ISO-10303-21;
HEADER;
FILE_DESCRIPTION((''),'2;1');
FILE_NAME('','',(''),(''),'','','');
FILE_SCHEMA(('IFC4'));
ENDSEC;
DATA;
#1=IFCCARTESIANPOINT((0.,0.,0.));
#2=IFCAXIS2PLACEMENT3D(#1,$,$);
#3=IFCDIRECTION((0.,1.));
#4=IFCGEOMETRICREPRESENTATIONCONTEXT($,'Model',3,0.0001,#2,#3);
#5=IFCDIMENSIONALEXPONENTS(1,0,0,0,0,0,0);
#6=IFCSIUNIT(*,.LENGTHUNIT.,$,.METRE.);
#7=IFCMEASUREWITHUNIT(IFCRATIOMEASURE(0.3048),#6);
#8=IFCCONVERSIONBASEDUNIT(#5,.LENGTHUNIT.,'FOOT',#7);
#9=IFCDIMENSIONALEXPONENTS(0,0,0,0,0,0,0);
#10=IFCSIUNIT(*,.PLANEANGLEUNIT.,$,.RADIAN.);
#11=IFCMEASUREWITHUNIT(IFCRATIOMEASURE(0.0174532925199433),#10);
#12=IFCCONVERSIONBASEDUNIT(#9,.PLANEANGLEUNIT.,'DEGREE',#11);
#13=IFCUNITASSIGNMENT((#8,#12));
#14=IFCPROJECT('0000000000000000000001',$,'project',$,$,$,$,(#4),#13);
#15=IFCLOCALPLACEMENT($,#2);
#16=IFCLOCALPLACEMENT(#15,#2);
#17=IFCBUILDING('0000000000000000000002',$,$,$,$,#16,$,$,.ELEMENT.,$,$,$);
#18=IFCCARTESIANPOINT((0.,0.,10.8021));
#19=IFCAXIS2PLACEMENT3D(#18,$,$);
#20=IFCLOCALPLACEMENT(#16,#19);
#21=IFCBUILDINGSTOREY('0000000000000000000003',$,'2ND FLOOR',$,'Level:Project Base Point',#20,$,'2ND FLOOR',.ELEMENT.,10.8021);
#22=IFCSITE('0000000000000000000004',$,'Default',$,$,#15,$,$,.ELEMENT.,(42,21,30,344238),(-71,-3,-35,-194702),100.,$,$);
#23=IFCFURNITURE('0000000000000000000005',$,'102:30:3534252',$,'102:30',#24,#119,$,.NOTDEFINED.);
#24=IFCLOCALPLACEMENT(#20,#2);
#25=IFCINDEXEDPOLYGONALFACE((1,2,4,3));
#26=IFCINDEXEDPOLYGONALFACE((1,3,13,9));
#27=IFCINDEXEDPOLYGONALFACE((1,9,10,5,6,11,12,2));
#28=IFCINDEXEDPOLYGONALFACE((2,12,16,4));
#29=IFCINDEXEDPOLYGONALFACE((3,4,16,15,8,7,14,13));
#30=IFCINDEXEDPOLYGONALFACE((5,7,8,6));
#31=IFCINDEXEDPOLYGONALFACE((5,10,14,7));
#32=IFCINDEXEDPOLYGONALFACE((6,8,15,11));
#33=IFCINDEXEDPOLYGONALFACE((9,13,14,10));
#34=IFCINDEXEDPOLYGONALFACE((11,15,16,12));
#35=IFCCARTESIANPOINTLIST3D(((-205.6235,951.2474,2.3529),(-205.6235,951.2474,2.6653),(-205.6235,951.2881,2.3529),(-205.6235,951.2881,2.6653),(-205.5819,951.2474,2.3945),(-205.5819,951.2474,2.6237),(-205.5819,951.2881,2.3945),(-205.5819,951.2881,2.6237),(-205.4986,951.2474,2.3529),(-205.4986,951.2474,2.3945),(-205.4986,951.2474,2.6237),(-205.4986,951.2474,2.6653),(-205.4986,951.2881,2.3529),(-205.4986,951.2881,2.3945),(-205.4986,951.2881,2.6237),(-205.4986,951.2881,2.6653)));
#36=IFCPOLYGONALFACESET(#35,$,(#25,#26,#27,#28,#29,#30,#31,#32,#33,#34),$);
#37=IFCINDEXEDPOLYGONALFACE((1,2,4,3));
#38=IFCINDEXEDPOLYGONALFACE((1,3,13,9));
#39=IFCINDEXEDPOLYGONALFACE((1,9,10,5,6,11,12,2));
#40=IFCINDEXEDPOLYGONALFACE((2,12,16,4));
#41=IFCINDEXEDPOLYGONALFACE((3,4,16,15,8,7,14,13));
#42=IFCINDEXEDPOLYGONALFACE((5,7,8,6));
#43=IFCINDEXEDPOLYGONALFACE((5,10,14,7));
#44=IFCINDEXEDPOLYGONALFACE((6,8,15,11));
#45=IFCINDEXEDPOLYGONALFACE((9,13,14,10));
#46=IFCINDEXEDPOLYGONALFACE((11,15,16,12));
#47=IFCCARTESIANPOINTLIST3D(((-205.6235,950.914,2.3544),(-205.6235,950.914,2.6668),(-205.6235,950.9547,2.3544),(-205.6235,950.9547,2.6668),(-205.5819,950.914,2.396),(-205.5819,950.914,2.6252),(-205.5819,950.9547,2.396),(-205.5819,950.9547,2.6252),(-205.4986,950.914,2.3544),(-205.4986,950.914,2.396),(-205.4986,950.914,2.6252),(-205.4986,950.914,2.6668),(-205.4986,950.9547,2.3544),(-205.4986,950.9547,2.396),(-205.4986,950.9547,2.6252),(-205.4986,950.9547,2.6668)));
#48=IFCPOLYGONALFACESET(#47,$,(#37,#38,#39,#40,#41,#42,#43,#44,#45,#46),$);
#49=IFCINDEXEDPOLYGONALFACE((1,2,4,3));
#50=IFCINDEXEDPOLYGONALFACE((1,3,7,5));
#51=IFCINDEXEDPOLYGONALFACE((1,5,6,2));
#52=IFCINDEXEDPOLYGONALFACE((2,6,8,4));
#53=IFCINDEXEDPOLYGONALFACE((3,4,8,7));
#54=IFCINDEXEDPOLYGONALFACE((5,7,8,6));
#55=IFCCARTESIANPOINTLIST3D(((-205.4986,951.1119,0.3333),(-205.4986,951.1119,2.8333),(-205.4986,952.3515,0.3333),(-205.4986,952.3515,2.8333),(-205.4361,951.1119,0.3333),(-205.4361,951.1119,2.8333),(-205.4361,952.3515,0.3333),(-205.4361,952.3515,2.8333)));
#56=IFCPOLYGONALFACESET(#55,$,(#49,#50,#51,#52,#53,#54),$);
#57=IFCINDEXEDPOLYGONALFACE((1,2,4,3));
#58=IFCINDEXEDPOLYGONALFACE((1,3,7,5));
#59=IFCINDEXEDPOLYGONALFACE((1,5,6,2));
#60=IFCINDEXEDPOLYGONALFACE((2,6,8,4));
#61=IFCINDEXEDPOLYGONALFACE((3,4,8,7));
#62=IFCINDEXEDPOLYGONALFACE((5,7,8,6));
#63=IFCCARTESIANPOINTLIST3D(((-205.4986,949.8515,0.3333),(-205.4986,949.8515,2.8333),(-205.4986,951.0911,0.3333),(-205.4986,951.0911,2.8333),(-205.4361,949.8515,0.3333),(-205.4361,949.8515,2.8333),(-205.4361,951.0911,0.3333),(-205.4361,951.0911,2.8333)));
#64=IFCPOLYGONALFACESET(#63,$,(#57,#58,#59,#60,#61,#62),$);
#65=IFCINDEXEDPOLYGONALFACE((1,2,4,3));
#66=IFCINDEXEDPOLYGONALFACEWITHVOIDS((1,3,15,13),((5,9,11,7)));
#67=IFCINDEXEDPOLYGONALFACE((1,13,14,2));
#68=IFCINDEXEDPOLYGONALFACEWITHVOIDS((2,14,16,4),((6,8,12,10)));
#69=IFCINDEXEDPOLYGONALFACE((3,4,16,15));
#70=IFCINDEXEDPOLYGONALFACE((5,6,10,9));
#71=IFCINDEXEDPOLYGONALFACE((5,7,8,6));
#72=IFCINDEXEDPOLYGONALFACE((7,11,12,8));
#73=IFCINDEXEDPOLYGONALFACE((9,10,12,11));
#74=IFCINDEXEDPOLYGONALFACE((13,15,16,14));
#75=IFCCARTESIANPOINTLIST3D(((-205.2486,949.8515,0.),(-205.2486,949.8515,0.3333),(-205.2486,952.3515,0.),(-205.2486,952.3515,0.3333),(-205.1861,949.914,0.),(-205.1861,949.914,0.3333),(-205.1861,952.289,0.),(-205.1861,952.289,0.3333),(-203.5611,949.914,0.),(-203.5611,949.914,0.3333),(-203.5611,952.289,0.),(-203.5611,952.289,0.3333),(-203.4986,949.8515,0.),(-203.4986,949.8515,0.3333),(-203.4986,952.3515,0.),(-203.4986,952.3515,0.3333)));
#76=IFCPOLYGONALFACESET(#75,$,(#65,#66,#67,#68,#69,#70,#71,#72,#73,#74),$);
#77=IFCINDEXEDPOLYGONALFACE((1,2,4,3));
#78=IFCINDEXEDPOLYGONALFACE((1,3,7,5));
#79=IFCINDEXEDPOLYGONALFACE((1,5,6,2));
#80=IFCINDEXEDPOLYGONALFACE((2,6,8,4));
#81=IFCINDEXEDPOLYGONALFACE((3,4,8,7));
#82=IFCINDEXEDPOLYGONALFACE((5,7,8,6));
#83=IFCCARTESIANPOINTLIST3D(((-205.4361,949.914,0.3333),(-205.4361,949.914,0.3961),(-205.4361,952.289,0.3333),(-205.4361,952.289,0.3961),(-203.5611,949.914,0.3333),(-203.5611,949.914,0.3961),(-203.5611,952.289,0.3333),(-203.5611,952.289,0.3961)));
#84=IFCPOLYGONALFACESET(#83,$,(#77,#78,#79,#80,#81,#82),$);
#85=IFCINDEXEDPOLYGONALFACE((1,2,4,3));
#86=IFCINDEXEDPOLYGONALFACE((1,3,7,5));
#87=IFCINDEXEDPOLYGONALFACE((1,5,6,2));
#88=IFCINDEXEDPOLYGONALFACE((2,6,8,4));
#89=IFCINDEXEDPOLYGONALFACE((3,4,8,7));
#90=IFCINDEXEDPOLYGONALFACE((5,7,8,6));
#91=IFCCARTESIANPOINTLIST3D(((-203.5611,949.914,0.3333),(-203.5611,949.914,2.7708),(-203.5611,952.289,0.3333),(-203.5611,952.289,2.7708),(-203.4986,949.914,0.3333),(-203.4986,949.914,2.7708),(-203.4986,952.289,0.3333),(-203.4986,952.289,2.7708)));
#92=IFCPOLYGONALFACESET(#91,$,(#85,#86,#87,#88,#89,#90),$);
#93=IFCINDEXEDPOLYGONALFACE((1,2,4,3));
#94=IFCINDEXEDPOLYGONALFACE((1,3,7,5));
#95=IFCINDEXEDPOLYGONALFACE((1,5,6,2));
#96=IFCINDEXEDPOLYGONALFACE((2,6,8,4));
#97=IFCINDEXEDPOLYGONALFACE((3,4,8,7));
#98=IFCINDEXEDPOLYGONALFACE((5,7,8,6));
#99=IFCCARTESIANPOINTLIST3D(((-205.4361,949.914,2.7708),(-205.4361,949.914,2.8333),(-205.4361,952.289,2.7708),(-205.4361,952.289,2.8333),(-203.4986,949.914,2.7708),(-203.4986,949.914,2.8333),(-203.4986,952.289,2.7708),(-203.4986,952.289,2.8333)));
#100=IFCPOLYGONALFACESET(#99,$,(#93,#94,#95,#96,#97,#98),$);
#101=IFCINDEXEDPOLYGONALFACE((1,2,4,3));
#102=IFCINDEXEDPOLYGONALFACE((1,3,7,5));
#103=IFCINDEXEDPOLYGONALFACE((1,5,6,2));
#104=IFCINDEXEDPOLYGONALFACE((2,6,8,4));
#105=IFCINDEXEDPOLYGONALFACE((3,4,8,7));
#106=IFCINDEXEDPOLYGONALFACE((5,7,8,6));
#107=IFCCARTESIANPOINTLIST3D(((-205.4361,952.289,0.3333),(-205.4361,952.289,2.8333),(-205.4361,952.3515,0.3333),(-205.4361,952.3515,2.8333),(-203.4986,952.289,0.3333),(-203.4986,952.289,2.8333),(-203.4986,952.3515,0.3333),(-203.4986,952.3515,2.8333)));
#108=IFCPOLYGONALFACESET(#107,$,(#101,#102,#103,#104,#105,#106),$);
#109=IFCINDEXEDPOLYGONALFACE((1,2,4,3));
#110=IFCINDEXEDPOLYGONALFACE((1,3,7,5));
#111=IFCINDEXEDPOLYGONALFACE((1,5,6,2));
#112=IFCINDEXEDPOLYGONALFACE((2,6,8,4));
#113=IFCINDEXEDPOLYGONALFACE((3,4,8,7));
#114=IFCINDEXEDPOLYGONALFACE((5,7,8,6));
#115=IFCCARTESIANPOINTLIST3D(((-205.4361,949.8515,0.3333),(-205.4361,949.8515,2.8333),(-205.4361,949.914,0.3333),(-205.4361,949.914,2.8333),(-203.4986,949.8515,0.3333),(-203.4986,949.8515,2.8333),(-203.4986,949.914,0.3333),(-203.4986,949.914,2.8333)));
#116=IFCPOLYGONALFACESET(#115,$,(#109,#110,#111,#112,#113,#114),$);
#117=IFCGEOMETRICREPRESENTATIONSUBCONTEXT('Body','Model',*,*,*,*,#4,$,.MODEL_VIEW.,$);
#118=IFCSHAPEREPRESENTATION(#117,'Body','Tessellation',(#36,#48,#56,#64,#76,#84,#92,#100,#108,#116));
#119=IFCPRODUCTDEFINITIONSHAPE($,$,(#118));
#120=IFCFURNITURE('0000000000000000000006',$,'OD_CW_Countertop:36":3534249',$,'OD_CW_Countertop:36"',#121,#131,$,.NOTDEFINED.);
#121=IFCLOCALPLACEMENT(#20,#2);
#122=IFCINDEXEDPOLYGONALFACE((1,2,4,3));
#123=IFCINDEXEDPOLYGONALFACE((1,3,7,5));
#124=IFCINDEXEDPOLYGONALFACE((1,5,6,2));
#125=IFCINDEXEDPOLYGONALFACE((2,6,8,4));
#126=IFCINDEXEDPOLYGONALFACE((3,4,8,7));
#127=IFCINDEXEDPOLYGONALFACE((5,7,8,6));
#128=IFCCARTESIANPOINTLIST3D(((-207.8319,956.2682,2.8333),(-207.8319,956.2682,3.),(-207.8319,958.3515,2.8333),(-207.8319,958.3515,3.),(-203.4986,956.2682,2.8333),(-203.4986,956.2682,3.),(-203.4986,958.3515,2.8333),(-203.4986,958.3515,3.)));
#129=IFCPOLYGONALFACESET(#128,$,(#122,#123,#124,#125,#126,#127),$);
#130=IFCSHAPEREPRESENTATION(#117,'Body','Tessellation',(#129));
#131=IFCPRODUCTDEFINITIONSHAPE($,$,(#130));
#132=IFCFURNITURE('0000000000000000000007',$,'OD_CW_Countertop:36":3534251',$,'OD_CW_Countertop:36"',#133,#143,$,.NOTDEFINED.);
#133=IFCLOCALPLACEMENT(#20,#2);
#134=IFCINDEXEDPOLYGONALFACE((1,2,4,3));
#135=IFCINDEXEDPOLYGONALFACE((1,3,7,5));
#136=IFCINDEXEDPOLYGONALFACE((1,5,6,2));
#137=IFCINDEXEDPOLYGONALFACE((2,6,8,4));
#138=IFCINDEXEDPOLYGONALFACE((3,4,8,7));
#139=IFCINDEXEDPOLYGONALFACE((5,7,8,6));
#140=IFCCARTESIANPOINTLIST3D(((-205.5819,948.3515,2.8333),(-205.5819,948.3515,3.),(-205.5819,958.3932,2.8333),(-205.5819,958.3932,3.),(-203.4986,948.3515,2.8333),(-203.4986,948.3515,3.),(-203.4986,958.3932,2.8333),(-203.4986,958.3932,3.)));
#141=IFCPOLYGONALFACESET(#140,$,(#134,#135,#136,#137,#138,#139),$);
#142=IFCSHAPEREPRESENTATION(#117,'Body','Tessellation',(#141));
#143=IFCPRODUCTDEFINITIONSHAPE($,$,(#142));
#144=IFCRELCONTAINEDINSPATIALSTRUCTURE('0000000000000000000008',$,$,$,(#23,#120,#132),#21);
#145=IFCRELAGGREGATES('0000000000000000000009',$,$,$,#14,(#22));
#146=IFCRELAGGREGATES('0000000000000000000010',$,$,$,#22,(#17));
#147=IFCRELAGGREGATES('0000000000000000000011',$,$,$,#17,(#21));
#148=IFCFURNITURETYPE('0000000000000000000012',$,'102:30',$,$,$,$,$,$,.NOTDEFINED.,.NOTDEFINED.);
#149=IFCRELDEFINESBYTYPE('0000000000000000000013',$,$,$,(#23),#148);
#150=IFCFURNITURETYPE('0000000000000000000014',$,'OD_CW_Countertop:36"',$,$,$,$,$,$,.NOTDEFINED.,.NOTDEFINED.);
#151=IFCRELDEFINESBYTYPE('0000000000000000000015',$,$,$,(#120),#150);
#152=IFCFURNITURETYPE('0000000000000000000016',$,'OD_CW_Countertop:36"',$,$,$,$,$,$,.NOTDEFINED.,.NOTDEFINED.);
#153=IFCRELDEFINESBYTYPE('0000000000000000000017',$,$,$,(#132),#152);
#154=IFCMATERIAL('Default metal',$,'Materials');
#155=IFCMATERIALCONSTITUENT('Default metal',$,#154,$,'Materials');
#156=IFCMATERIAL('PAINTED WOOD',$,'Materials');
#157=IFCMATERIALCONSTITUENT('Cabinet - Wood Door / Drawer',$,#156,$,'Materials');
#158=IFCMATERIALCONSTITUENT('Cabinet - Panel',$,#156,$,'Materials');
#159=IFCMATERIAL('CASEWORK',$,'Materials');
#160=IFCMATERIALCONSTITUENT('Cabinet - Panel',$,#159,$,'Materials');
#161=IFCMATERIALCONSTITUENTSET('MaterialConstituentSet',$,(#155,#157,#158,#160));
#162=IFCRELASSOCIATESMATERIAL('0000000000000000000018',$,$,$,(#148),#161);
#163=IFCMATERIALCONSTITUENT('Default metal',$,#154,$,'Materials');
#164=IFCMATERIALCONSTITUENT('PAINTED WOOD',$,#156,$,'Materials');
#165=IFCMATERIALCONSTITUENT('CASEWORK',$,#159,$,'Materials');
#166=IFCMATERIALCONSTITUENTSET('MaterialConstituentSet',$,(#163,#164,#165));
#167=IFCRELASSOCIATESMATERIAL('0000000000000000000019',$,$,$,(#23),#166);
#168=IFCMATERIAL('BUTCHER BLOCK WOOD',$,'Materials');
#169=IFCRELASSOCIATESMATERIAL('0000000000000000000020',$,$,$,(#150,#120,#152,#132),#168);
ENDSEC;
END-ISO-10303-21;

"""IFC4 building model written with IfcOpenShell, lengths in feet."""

from ifc_helpers import new_model, entity, si_unit, converted_unit, direction, frame, frame_2d, origin, origin_2d_with_axis, place, context, subcontext, project, spatial, polyline, rectangle, outline, extrude, source, transform, mapped, material, constituent, constituent_set, type_object, type_shapes, element, save


model = new_model("IFC4")

# Units and contexts
model_context = context("Model", 3, precision=0.0001, world=origin(), true_north=direction((0.0, 1.0)))
body_context = subcontext(model_context, "Body", "Model", "MODEL_VIEW")
ifc_project = project(units=[converted_unit("LENGTHUNIT", "FOOT", entity("IfcRatioMeasure", 0.3048), si_unit("LENGTHUNIT", "METRE"), dimensions=[1, 0, 0, 0, 0, 0, 0]), converted_unit("PLANEANGLEUNIT", "DEGREE", entity("IfcRatioMeasure", 0.0174532925199433), si_unit("PLANEANGLEUNIT", "RADIAN"), dimensions=[0, 0, 0, 0, 0, 0, 0])], contexts=[model_context])

# Site, building, storey
site_placement = place(None, origin())
site = spatial("IfcSite", under=ifc_project, at=site_placement, Name="Default", CompositionType="ELEMENT", RefLatitude=(42, 21, 30, 344238), RefLongitude=(-71, -3, -35, -194702), RefElevation=100.0)
building_placement = place(site_placement, origin())
building = spatial("IfcBuilding", under=site, at=building_placement, CompositionType="ELEMENT")
storey_placement = place(building_placement, frame((0.0, 0.0, 10.8021)))
storey = spatial("IfcBuildingStorey", under=building, at=storey_placement, Name="2ND FLOOR", ObjectType="Level:Project Base Point", LongName="2ND FLOOR", CompositionType="ELEMENT", Elevation=10.8021)

# Furniture
ifc_material_1 = material(Name="CASEWORK", Category="Materials")
ifc_material_2 = material(Name="PAINTED WOOD", Category="Materials")
ifc_material_3 = material(Name="Default metal", Category="Materials")
ifc_constituent_1 = constituent(ifc_material_3, Name="Default metal", Category="Materials")
ifc_constituent_2 = constituent(ifc_material_2, Name="PAINTED WOOD", Category="Materials")
ifc_constituent_3 = constituent(ifc_material_1, Name="CASEWORK", Category="Materials")
ifc_constituent_set_1 = constituent_set(constituents=[ifc_constituent_1, ifc_constituent_2, ifc_constituent_3], Name="MaterialConstituentSet")
ifc_constituent_4 = constituent(ifc_material_3, Name="Default metal", Category="Materials")
ifc_constituent_5 = constituent(ifc_material_2, Name="Cabinet - Wood Door / Drawer", Category="Materials")
ifc_constituent_6 = constituent(ifc_material_2, Name="Cabinet - Panel", Category="Materials")
ifc_constituent_7 = constituent(ifc_material_1, Name="Cabinet - Panel", Category="Materials")
ifc_constituent_set_2 = constituent_set(constituents=[ifc_constituent_4, ifc_constituent_5, ifc_constituent_6, ifc_constituent_7], Name="MaterialConstituentSet")
furniture_type_1 = type_object("IfcFurnitureType", Name="102:30", AssemblyPlace="NOTDEFINED", PredefinedType="NOTDEFINED", material=ifc_constituent_set_2)
shared_shape_1 = source(origin(), body_context, "Body", "SweptSolid", [
    extrude(outline(polyline([(-0.0521, -0.1146), (-0.0521, -0.1562), (0.0729, -0.1562), (0.0729, 0.1562), (-0.0521, 0.1562), (-0.0521, 0.1146), (0.0313, 0.1146), (0.0313, -0.1146), (-0.0521, -0.1146)])), frame((0.2073, 2.0521, 2.5091), z_axis=(-1.0, 0.0, 0.0), x_axis=(0.0, 1.0, 0.0)), (0.0, 0.0, -1.0), 0.0407),
    extrude(outline(polyline([(-0.0521, -0.1146), (-0.0521, -0.1562), (0.0729, -0.1562), (0.0729, 0.1562), (-0.0521, 0.1562), (-0.0521, 0.1146), (0.0313, 0.1146), (0.0313, -0.1146), (-0.0521, -0.1146)])), frame((-0.126, 2.0521, 2.5106), z_axis=(-1.0, 0.0, 0.0), x_axis=(0.0, 1.0, 0.0)), (0.0, 0.0, -1.0), 0.0407),
    extrude(rectangle(XDim=1.2396, YDim=0.0625, at=frame_2d((0.0, 0.0), x_axis=(1.0, 0.0))), frame((0.6917, 1.9688, 0.3333), z_axis=(0.0, 0.0, 1.0), x_axis=(-1.0, 0.0, 0.0)), (0.0, 0.0, 1.0), 2.5),
    extrude(rectangle(XDim=1.2396, YDim=0.0625, at=origin_2d_with_axis()), frame((-0.5687, 1.9688, 0.3333), z_axis=(0.0, 0.0, 1.0), x_axis=(-1.0, 0.0, 0.0)), (0.0, 0.0, 1.0), 2.5),
    extrude(outline(polyline([(-0.875, -1.25), (0.875, -1.25), (0.875, 1.25), (-0.875, 1.25), (-0.875, -1.25)]), holes=[polyline([(-0.8125, -1.1875), (-0.8125, 1.1875), (0.8125, 1.1875), (0.8125, -1.1875), (-0.8125, -1.1875)])]), frame((0.0615, 0.875, 0.0), z_axis=(0.0, 0.0, 1.0), x_axis=(0.0, -1.0, 0.0)), (0.0, 0.0, 1.0), 0.3333),
    extrude(rectangle(XDim=1.875, YDim=2.375, at=origin_2d_with_axis()), frame((0.0615, 1.0, 0.3333), z_axis=(0.0, 0.0, 1.0), x_axis=(0.0, 1.0, 0.0)), (0.0, 0.0, 1.0), 0.0627),
    extrude(rectangle(XDim=2.375, YDim=0.0625, at=origin_2d_with_axis()), frame((0.0615, 0.0312, 0.3333), z_axis=(0.0, 0.0, 1.0), x_axis=(-1.0, 0.0, 0.0)), (0.0, 0.0, 1.0), 2.4375),
    extrude(rectangle(XDim=1.9375, YDim=2.375, at=frame_2d((0.0, 0.0), x_axis=(1.0, 0.0))), frame((0.0615, 0.9688, 2.7708), z_axis=(0.0, 0.0, 1.0), x_axis=(0.0, 1.0, 0.0)), (0.0, 0.0, 1.0), 0.0625),
    extrude(rectangle(XDim=1.9375, YDim=0.0625, at=frame_2d((0.0, 0.0), x_axis=(1.0, 0.0))), frame((1.2802, 0.9687, 0.3333), z_axis=(0.0, 0.0, 1.0), x_axis=(0.0, -1.0, 0.0)), (0.0, 0.0, 1.0), 2.5),
    extrude(rectangle(XDim=1.9375, YDim=0.0625, at=frame_2d((0.0, 0.0), x_axis=(1.0, 0.0))), frame((-1.1573, 0.9687, 0.3333), z_axis=(0.0, 0.0, 1.0), x_axis=(0.0, -1.0, 0.0)), (0.0, 0.0, 1.0), 2.5),
])
type_shapes(furniture_type_1, [shared_shape_1])
furniture_1_placement = place(storey_placement, frame((-203.4986, 951.04, 0.0), z_axis=(0.0, 0.0, 1.0), x_axis=(0.0, 1.0, 0.0)))
element("IfcFurniture", 1, at=furniture_1_placement, inside=storey, type_object=furniture_type_1, material=ifc_constituent_set_1, Name="102:30:3534252", ObjectType="102:30", PredefinedType="NOTDEFINED", context=body_context, shape_type="MappedRepresentation", body=[
    mapped(shared_shape_1, transform((0.0, 0.0, 0.0), scale=1.0)),
])
ifc_material_4 = material(Name="BUTCHER BLOCK WOOD", Category="Materials")
furniture_type_2 = type_object("IfcFurnitureType", Name="OD_CW_Countertop:36\"", AssemblyPlace="NOTDEFINED", PredefinedType="NOTDEFINED", material=ifc_material_4)
shared_shape_2 = source(origin(), body_context, "Body", "SweptSolid", [
    extrude(rectangle(XDim=2.0833, YDim=4.3333, at=frame_2d((0.0, 0.0), x_axis=(1.0, 0.0))), frame((2.1667, 1.0417, 0.0), z_axis=(0.0, 0.0, 1.0), x_axis=(0.0, -1.0, 0.0)), (0.0, 0.0, 1.0), 0.1667),
])
type_shapes(furniture_type_2, [shared_shape_2])
furniture_2_placement = place(storey_placement, frame((-207.8319, 956.2682, 2.8333)))
element("IfcFurniture", 2, at=furniture_2_placement, inside=storey, type_object=furniture_type_2, material=ifc_material_4, Name="OD_CW_Countertop:36\":3534249", ObjectType="OD_CW_Countertop:36\"", PredefinedType="NOTDEFINED", context=body_context, shape_type="MappedRepresentation", body=[
    mapped(shared_shape_2, transform((0.0, 0.0, 0.0), scale=1.0)),
])
furniture_type_3 = type_object("IfcFurnitureType", Name="OD_CW_Countertop:36\"", AssemblyPlace="NOTDEFINED", PredefinedType="NOTDEFINED", material=ifc_material_4)
shared_shape_3 = source(origin(), body_context, "Body", "SweptSolid", [
    extrude(rectangle(XDim=2.0833, YDim=10.0417, at=origin_2d_with_axis()), frame((5.0208, 1.0417, 0.0), z_axis=(0.0, 0.0, 1.0), x_axis=(0.0, -1.0, 0.0)), (0.0, 0.0, 1.0), 0.1667),
])
type_shapes(furniture_type_3, [shared_shape_3])
furniture_3_placement = place(storey_placement, frame((-205.5819, 958.3932, 2.8333), z_axis=(0.0, 0.0, 1.0), x_axis=(0.0, -1.0, 0.0)))
element("IfcFurniture", 3, at=furniture_3_placement, inside=storey, type_object=furniture_type_3, material=ifc_material_4, Name="OD_CW_Countertop:36\":3534251", ObjectType="OD_CW_Countertop:36\"", PredefinedType="NOTDEFINED", context=body_context, shape_type="MappedRepresentation", body=[
    mapped(shared_shape_3, transform((0.0, 0.0, 0.0), scale=1.0)),
])

save(model, "model.ifc")
